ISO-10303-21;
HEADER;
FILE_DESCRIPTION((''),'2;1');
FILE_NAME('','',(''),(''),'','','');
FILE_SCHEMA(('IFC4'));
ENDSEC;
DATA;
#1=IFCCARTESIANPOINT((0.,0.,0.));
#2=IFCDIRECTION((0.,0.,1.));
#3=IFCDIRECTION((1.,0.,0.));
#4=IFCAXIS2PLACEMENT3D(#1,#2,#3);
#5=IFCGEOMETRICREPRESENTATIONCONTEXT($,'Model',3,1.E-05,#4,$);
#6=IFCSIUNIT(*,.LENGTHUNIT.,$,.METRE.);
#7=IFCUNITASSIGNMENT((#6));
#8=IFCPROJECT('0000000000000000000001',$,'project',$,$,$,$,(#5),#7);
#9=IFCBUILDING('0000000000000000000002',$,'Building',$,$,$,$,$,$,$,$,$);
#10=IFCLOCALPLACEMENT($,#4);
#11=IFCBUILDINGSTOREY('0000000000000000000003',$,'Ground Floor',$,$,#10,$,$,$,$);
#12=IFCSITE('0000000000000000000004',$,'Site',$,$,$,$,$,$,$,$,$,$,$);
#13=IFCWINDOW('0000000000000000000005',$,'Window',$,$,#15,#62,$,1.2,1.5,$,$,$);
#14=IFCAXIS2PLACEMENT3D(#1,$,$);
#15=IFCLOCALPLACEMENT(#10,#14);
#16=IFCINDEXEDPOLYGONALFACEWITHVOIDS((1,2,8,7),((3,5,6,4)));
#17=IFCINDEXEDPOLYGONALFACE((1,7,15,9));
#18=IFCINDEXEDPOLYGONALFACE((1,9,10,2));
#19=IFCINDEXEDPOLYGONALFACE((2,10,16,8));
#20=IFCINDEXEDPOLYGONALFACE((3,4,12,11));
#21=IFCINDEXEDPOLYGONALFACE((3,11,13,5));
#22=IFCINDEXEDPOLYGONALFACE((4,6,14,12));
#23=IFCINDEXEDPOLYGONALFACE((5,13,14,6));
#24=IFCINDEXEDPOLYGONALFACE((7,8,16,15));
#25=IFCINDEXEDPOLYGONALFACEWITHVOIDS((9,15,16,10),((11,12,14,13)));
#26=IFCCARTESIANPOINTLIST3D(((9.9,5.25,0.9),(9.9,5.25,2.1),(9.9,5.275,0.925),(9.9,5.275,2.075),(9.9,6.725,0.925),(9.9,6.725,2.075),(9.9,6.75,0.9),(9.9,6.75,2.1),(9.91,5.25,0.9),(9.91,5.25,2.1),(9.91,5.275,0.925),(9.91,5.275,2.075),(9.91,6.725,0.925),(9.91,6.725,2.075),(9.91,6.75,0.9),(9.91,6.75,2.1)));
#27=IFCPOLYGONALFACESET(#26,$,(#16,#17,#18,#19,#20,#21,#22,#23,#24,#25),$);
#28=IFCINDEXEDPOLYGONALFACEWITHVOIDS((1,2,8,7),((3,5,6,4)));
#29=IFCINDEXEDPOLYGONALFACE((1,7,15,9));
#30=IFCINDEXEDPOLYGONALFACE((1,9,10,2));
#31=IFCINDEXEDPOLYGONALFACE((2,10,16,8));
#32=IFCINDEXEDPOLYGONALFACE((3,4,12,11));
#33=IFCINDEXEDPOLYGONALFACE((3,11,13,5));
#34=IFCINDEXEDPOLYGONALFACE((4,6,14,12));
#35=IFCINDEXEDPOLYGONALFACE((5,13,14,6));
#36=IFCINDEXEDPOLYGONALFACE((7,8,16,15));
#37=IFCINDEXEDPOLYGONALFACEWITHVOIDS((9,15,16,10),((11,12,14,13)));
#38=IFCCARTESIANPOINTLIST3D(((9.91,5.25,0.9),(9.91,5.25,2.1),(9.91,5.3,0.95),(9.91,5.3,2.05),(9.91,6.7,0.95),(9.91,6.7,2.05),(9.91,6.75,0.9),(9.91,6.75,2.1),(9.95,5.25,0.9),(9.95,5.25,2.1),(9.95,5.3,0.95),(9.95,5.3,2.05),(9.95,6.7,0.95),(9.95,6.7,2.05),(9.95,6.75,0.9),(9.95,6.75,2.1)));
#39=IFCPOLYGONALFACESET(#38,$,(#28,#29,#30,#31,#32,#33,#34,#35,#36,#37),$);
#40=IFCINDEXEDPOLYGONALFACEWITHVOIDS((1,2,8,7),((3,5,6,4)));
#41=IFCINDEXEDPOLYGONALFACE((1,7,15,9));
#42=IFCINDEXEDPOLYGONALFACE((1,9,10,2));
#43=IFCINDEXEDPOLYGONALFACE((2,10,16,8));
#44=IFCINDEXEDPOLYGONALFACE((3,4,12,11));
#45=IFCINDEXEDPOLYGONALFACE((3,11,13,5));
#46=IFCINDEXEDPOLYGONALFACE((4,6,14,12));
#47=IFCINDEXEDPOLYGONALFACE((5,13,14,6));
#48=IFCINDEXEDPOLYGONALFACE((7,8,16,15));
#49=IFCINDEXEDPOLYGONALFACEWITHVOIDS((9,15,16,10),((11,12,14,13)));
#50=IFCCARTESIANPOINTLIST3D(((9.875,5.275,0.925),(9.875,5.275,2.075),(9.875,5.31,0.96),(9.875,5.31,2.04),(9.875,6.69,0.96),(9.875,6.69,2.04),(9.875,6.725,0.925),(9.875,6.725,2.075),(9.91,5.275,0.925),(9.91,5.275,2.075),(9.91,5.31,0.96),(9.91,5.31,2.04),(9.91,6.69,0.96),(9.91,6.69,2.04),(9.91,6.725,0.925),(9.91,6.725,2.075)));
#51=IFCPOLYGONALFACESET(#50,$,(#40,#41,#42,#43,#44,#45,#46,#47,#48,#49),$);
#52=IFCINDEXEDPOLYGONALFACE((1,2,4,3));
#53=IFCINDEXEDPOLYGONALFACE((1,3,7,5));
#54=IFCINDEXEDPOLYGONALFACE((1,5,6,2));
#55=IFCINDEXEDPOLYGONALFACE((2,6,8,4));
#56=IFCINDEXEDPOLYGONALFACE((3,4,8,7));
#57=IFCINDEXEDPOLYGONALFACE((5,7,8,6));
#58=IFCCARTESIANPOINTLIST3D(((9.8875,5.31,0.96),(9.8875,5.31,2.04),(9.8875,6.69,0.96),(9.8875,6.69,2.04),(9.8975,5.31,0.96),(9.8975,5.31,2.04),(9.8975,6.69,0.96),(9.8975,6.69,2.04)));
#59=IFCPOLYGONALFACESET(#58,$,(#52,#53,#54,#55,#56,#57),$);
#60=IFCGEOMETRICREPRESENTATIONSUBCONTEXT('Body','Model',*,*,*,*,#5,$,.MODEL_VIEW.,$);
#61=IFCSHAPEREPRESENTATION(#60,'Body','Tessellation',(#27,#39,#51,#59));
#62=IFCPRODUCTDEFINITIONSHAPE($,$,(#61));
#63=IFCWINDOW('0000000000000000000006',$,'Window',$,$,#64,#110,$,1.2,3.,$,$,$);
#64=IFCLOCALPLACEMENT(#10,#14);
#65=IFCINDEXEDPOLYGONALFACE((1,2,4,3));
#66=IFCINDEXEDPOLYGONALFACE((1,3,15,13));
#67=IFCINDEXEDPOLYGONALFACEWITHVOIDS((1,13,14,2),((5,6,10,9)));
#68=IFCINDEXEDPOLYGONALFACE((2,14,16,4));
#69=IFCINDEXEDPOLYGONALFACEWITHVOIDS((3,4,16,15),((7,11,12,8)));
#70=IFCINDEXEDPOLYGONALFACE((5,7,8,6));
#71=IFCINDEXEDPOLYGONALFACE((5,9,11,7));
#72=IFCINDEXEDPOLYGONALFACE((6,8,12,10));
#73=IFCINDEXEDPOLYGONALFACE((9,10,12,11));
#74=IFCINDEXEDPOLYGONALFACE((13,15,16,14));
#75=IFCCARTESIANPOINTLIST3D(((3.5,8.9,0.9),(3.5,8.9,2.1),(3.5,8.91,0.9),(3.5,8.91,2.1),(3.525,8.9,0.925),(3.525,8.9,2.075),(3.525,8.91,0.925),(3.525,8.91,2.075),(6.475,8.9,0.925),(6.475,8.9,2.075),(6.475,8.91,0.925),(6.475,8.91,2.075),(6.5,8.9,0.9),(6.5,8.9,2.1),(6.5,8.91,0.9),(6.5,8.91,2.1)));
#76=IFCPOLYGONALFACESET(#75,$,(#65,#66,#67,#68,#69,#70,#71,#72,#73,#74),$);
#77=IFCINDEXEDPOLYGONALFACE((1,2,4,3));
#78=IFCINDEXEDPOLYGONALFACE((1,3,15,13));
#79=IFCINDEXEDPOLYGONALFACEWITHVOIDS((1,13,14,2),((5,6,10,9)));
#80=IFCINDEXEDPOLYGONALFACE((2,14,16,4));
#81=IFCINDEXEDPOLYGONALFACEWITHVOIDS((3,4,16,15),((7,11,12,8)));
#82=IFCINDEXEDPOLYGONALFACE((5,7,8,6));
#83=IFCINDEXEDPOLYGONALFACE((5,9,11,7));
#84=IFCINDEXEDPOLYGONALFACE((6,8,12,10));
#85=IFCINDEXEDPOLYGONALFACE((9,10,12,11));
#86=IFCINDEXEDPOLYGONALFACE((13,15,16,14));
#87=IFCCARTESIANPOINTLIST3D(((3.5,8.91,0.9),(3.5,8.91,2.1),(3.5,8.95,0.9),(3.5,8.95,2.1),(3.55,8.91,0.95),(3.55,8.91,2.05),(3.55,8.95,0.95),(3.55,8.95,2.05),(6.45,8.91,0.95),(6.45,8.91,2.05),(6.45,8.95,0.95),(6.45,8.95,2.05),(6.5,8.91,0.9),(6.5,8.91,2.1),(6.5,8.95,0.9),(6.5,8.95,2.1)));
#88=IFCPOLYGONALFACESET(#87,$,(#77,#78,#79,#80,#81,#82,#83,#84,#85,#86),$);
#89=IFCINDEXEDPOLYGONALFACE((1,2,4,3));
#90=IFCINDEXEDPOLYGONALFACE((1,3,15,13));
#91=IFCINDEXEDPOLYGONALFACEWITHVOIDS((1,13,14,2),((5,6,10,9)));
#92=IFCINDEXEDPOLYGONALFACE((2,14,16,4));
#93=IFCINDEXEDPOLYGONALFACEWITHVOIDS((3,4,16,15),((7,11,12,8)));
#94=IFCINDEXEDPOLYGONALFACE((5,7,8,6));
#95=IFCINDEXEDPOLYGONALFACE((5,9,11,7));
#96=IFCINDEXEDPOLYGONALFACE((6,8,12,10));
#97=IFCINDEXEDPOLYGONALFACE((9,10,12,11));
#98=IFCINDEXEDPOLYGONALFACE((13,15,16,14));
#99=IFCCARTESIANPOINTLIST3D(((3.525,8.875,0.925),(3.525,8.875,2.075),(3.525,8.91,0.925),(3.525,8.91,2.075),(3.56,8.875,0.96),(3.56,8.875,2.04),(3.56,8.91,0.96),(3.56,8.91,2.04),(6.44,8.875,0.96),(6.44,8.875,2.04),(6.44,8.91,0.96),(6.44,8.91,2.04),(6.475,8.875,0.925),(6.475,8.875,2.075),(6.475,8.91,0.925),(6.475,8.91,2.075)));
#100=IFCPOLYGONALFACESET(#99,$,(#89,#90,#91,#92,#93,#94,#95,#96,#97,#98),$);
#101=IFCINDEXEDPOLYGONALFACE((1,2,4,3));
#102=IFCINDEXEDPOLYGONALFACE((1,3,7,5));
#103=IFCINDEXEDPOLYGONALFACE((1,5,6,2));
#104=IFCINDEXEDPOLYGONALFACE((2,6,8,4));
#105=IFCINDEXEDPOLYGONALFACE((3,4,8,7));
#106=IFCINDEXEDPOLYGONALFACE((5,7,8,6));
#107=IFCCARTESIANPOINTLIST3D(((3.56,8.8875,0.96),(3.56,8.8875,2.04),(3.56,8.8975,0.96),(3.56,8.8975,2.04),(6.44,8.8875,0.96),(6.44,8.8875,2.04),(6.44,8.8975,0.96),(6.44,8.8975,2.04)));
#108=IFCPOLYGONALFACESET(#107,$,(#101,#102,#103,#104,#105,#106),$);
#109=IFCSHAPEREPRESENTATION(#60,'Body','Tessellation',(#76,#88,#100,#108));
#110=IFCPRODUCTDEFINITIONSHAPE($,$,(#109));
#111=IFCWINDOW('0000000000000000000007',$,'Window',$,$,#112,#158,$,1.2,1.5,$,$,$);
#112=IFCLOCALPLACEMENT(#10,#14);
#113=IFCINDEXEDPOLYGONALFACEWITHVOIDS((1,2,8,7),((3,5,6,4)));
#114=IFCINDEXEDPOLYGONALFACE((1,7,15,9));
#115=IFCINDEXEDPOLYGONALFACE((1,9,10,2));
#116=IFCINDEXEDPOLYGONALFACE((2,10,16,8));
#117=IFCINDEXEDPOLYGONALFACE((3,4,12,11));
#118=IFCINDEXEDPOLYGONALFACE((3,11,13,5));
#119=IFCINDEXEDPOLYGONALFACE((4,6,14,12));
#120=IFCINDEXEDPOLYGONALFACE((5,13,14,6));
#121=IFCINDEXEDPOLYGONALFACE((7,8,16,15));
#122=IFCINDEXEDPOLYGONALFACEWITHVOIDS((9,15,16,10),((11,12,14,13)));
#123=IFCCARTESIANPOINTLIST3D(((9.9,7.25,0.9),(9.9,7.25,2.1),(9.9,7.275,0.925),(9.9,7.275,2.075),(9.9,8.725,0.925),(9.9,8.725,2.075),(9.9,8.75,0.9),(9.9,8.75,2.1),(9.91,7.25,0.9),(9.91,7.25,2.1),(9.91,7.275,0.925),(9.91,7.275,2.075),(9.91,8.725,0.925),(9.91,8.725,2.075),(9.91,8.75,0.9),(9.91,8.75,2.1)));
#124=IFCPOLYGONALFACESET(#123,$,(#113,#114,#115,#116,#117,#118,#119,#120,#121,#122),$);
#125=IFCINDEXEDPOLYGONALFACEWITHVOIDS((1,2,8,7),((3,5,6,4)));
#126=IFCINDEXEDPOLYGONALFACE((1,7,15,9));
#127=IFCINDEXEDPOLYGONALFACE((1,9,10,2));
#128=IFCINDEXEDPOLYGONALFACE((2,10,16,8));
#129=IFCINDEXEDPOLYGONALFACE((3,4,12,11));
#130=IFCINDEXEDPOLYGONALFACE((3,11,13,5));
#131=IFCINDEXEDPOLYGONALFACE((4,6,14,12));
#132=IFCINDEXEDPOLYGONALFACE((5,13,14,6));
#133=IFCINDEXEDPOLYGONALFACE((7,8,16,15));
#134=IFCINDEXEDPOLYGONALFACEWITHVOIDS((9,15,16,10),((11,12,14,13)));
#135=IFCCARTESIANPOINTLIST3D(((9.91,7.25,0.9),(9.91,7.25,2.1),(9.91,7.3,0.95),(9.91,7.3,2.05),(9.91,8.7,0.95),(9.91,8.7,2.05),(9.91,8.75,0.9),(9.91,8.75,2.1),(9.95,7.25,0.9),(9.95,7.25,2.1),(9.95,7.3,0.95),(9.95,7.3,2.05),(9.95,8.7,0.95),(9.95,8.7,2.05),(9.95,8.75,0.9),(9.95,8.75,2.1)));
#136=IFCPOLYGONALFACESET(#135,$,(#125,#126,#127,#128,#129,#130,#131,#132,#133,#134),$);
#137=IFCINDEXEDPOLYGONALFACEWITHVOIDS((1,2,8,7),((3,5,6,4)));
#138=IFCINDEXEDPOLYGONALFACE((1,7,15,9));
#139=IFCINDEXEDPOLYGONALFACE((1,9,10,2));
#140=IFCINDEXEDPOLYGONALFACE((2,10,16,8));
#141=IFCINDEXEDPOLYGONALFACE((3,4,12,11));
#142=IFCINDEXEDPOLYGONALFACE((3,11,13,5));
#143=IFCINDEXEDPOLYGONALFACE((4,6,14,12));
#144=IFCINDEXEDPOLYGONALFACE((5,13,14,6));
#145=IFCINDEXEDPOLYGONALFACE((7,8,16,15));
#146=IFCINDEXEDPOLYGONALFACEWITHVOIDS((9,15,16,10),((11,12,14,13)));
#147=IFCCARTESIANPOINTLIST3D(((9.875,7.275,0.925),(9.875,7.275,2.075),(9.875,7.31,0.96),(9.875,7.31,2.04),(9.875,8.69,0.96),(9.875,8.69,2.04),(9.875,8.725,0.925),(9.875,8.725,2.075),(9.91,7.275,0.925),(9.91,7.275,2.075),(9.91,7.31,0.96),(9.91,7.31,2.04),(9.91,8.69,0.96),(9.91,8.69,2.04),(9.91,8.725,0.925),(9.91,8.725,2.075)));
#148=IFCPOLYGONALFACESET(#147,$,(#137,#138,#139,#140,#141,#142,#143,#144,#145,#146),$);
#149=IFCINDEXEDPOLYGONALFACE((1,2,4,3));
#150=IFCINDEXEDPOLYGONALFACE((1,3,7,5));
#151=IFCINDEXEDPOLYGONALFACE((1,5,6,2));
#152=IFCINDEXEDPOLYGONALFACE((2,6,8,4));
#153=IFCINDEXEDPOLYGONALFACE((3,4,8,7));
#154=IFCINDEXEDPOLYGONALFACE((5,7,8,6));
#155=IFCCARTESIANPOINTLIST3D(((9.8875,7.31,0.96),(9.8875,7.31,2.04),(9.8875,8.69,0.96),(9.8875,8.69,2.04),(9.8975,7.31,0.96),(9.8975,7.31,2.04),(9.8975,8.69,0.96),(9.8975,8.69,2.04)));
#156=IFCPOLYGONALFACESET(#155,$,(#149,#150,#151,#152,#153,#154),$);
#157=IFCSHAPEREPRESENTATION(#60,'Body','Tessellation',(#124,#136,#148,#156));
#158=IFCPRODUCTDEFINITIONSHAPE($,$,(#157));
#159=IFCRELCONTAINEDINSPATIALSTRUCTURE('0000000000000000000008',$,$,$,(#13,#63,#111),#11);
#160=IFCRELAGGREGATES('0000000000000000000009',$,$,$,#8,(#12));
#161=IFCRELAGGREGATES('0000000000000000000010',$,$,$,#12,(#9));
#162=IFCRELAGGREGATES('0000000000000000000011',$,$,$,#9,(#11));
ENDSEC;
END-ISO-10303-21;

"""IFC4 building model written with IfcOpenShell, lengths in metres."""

from ifc_helpers import new_model, si_unit, frame, origin_with_axes, place, context, subcontext, project, spatial, line, indexed_curve, outline, extrude, element, save


model = new_model("IFC4")

# Units and contexts
model_context = context("Model", 3, precision=1e-05, world=origin_with_axes())
body_context = subcontext(model_context, "Body", "Model", "MODEL_VIEW")
ifc_project = project(units=[si_unit("LENGTHUNIT", "METRE")], contexts=[model_context])

# Site, building, storey
site = spatial("IfcSite", under=ifc_project, Name="Site")
building = spatial("IfcBuilding", under=site, Name="Building")
storey_placement = place(None, origin_with_axes())
storey = spatial("IfcBuildingStorey", under=building, at=storey_placement, Name="Ground Floor")

# Windows
for number, where, z_axis, x_axis, name in (
    (1, (10.0, 5.25, 0.9), (0.0, 0.0, 1.0), (0.0, 1.0, 0.0), "Window"),
):
    element("IfcWindow", number, at=place(storey_placement, frame(where, z_axis=z_axis, x_axis=x_axis)), inside=storey, Name=name, OverallHeight=1.2, OverallWidth=1.5, context=body_context, shape_type="SweptSolid", body=[
        extrude(outline(indexed_curve([(0.0, 0.0), (1.5, 0.0), (1.5, 1.2), (0.0, 1.2)], segments=[line(1, 2, 3, 4, 1)]), holes=[indexed_curve([(0.025, 0.025), (1.475, 0.025), (1.475, 1.175), (0.025, 1.175)], segments=[line(1, 2, 3, 4, 1)])]), frame((0.0, 0.09, 0.0), z_axis=(0.0, -1.0, 0.0), x_axis=(1.0, 0.0, 0.0)), (0.0, 0.0, -1.0), 0.01),
        extrude(outline(indexed_curve([(0.0, 0.0), (1.5, 0.0), (1.5, 1.2), (0.0, 1.2)], segments=[line(1, 2, 3, 4, 1)]), holes=[indexed_curve([(0.05, 0.05), (1.45, 0.05), (1.45, 1.15), (0.05, 1.15)], segments=[line(1, 2, 3, 4, 1)])]), frame((0.0, 0.05, 0.0), z_axis=(0.0, -1.0, 0.0), x_axis=(1.0, 0.0, 0.0)), (0.0, 0.0, -1.0), 0.04),
        extrude(outline(indexed_curve([(0.0, 0.0), (1.45, 0.0), (1.45, 1.15), (0.0, 1.15)], segments=[line(1, 2, 3, 4, 1)]), holes=[indexed_curve([(0.035, 0.035), (1.415, 0.035), (1.415, 1.115), (0.035, 1.115)], segments=[line(1, 2, 3, 4, 1)])]), frame((0.025, 0.09, 0.025), z_axis=(0.0, -1.0, 0.0), x_axis=(1.0, 0.0, 0.0)), (0.0, 0.0, -1.0), 0.035),
        extrude(outline(indexed_curve([(0.035, 0.035), (1.415, 0.035), (1.415, 1.115), (0.035, 1.115)], segments=[line(1, 2, 3, 4, 1)])), frame((0.025, 0.1025, 0.025), z_axis=(0.0, -1.0, 0.0), x_axis=(1.0, 0.0, 0.0)), (0.0, 0.0, -1.0), 0.01),
    ])
window_1_placement = place(storey_placement, frame((6.5, 9.0, 0.9), z_axis=(0.0, 0.0, 1.0), x_axis=(-1.0, 0.0, 0.0)))
element("IfcWindow", 2, at=window_1_placement, inside=storey, Name="Window", OverallHeight=1.2, OverallWidth=3.0, context=body_context, shape_type="SweptSolid", body=[
    extrude(outline(indexed_curve([(0.0, 0.0), (3.0, 0.0), (3.0, 1.2), (0.0, 1.2)], segments=[line(1, 2, 3, 4, 1)]), holes=[indexed_curve([(0.025, 0.025), (2.975, 0.025), (2.975, 1.175), (0.025, 1.175)], segments=[line(1, 2, 3, 4, 1)])]), frame((0.0, 0.09, 0.0), z_axis=(0.0, -1.0, 0.0), x_axis=(1.0, 0.0, 0.0)), (0.0, 0.0, -1.0), 0.01),
    extrude(outline(indexed_curve([(0.0, 0.0), (3.0, 0.0), (3.0, 1.2), (0.0, 1.2)], segments=[line(1, 2, 3, 4, 1)]), holes=[indexed_curve([(0.05, 0.05), (2.95, 0.05), (2.95, 1.15), (0.05, 1.15)], segments=[line(1, 2, 3, 4, 1)])]), frame((0.0, 0.05, 0.0), z_axis=(0.0, -1.0, 0.0), x_axis=(1.0, 0.0, 0.0)), (0.0, 0.0, -1.0), 0.04),
    extrude(outline(indexed_curve([(0.0, 0.0), (2.95, 0.0), (2.95, 1.15), (0.0, 1.15)], segments=[line(1, 2, 3, 4, 1)]), holes=[indexed_curve([(0.035, 0.035), (2.915, 0.035), (2.915, 1.115), (0.035, 1.115)], segments=[line(1, 2, 3, 4, 1)])]), frame((0.025, 0.09, 0.025), z_axis=(0.0, -1.0, 0.0), x_axis=(1.0, 0.0, 0.0)), (0.0, 0.0, -1.0), 0.035),
    extrude(outline(indexed_curve([(0.035, 0.035), (2.915, 0.035), (2.915, 1.115), (0.035, 1.115)], segments=[line(1, 2, 3, 4, 1)])), frame((0.025, 0.1025, 0.025), z_axis=(0.0, -1.0, 0.0), x_axis=(1.0, 0.0, 0.0)), (0.0, 0.0, -1.0), 0.01),
])
window_2_placement = place(storey_placement, frame((10.0, 7.25, 0.9), z_axis=(0.0, 0.0, 1.0), x_axis=(0.0, 1.0, 0.0)))
element("IfcWindow", 3, at=window_2_placement, inside=storey, Name="Window", OverallHeight=1.2, OverallWidth=1.5, context=body_context, shape_type="SweptSolid", body=[
    extrude(outline(indexed_curve([(0.0, 0.0), (1.5, 0.0), (1.5, 1.2), (0.0, 1.2)], segments=[line(1, 2, 3, 4, 1)]), holes=[indexed_curve([(0.025, 0.025), (1.475, 0.025), (1.475, 1.175), (0.025, 1.175)], segments=[line(1, 2, 3, 4, 1)])]), frame((0.0, 0.09, 0.0), z_axis=(0.0, -1.0, 0.0), x_axis=(1.0, 0.0, 0.0)), (0.0, 0.0, -1.0), 0.01),
    extrude(outline(indexed_curve([(0.0, 0.0), (1.5, 0.0), (1.5, 1.2), (0.0, 1.2)], segments=[line(1, 2, 3, 4, 1)]), holes=[indexed_curve([(0.05, 0.05), (1.45, 0.05), (1.45, 1.15), (0.05, 1.15)], segments=[line(1, 2, 3, 4, 1)])]), frame((0.0, 0.05, 0.0), z_axis=(0.0, -1.0, 0.0), x_axis=(1.0, 0.0, 0.0)), (0.0, 0.0, -1.0), 0.04),
    extrude(outline(indexed_curve([(0.0, 0.0), (1.45, 0.0), (1.45, 1.15), (0.0, 1.15)], segments=[line(1, 2, 3, 4, 1)]), holes=[indexed_curve([(0.035, 0.035), (1.415, 0.035), (1.415, 1.115), (0.035, 1.115)], segments=[line(1, 2, 3, 4, 1)])]), frame((0.025, 0.09, 0.025), z_axis=(0.0, -1.0, 0.0), x_axis=(1.0, 0.0, 0.0)), (0.0, 0.0, -1.0), 0.035),
    extrude(outline(indexed_curve([(0.035, 0.035), (1.415, 0.035), (1.415, 1.115), (0.035, 1.115)], segments=[line(1, 2, 3, 4, 1)])), frame((0.025, 0.1025, 0.025), z_axis=(0.0, -1.0, 0.0), x_axis=(1.0, 0.0, 0.0)), (0.0, 0.0, -1.0), 0.01),
])

save(model, "model.ifc")
